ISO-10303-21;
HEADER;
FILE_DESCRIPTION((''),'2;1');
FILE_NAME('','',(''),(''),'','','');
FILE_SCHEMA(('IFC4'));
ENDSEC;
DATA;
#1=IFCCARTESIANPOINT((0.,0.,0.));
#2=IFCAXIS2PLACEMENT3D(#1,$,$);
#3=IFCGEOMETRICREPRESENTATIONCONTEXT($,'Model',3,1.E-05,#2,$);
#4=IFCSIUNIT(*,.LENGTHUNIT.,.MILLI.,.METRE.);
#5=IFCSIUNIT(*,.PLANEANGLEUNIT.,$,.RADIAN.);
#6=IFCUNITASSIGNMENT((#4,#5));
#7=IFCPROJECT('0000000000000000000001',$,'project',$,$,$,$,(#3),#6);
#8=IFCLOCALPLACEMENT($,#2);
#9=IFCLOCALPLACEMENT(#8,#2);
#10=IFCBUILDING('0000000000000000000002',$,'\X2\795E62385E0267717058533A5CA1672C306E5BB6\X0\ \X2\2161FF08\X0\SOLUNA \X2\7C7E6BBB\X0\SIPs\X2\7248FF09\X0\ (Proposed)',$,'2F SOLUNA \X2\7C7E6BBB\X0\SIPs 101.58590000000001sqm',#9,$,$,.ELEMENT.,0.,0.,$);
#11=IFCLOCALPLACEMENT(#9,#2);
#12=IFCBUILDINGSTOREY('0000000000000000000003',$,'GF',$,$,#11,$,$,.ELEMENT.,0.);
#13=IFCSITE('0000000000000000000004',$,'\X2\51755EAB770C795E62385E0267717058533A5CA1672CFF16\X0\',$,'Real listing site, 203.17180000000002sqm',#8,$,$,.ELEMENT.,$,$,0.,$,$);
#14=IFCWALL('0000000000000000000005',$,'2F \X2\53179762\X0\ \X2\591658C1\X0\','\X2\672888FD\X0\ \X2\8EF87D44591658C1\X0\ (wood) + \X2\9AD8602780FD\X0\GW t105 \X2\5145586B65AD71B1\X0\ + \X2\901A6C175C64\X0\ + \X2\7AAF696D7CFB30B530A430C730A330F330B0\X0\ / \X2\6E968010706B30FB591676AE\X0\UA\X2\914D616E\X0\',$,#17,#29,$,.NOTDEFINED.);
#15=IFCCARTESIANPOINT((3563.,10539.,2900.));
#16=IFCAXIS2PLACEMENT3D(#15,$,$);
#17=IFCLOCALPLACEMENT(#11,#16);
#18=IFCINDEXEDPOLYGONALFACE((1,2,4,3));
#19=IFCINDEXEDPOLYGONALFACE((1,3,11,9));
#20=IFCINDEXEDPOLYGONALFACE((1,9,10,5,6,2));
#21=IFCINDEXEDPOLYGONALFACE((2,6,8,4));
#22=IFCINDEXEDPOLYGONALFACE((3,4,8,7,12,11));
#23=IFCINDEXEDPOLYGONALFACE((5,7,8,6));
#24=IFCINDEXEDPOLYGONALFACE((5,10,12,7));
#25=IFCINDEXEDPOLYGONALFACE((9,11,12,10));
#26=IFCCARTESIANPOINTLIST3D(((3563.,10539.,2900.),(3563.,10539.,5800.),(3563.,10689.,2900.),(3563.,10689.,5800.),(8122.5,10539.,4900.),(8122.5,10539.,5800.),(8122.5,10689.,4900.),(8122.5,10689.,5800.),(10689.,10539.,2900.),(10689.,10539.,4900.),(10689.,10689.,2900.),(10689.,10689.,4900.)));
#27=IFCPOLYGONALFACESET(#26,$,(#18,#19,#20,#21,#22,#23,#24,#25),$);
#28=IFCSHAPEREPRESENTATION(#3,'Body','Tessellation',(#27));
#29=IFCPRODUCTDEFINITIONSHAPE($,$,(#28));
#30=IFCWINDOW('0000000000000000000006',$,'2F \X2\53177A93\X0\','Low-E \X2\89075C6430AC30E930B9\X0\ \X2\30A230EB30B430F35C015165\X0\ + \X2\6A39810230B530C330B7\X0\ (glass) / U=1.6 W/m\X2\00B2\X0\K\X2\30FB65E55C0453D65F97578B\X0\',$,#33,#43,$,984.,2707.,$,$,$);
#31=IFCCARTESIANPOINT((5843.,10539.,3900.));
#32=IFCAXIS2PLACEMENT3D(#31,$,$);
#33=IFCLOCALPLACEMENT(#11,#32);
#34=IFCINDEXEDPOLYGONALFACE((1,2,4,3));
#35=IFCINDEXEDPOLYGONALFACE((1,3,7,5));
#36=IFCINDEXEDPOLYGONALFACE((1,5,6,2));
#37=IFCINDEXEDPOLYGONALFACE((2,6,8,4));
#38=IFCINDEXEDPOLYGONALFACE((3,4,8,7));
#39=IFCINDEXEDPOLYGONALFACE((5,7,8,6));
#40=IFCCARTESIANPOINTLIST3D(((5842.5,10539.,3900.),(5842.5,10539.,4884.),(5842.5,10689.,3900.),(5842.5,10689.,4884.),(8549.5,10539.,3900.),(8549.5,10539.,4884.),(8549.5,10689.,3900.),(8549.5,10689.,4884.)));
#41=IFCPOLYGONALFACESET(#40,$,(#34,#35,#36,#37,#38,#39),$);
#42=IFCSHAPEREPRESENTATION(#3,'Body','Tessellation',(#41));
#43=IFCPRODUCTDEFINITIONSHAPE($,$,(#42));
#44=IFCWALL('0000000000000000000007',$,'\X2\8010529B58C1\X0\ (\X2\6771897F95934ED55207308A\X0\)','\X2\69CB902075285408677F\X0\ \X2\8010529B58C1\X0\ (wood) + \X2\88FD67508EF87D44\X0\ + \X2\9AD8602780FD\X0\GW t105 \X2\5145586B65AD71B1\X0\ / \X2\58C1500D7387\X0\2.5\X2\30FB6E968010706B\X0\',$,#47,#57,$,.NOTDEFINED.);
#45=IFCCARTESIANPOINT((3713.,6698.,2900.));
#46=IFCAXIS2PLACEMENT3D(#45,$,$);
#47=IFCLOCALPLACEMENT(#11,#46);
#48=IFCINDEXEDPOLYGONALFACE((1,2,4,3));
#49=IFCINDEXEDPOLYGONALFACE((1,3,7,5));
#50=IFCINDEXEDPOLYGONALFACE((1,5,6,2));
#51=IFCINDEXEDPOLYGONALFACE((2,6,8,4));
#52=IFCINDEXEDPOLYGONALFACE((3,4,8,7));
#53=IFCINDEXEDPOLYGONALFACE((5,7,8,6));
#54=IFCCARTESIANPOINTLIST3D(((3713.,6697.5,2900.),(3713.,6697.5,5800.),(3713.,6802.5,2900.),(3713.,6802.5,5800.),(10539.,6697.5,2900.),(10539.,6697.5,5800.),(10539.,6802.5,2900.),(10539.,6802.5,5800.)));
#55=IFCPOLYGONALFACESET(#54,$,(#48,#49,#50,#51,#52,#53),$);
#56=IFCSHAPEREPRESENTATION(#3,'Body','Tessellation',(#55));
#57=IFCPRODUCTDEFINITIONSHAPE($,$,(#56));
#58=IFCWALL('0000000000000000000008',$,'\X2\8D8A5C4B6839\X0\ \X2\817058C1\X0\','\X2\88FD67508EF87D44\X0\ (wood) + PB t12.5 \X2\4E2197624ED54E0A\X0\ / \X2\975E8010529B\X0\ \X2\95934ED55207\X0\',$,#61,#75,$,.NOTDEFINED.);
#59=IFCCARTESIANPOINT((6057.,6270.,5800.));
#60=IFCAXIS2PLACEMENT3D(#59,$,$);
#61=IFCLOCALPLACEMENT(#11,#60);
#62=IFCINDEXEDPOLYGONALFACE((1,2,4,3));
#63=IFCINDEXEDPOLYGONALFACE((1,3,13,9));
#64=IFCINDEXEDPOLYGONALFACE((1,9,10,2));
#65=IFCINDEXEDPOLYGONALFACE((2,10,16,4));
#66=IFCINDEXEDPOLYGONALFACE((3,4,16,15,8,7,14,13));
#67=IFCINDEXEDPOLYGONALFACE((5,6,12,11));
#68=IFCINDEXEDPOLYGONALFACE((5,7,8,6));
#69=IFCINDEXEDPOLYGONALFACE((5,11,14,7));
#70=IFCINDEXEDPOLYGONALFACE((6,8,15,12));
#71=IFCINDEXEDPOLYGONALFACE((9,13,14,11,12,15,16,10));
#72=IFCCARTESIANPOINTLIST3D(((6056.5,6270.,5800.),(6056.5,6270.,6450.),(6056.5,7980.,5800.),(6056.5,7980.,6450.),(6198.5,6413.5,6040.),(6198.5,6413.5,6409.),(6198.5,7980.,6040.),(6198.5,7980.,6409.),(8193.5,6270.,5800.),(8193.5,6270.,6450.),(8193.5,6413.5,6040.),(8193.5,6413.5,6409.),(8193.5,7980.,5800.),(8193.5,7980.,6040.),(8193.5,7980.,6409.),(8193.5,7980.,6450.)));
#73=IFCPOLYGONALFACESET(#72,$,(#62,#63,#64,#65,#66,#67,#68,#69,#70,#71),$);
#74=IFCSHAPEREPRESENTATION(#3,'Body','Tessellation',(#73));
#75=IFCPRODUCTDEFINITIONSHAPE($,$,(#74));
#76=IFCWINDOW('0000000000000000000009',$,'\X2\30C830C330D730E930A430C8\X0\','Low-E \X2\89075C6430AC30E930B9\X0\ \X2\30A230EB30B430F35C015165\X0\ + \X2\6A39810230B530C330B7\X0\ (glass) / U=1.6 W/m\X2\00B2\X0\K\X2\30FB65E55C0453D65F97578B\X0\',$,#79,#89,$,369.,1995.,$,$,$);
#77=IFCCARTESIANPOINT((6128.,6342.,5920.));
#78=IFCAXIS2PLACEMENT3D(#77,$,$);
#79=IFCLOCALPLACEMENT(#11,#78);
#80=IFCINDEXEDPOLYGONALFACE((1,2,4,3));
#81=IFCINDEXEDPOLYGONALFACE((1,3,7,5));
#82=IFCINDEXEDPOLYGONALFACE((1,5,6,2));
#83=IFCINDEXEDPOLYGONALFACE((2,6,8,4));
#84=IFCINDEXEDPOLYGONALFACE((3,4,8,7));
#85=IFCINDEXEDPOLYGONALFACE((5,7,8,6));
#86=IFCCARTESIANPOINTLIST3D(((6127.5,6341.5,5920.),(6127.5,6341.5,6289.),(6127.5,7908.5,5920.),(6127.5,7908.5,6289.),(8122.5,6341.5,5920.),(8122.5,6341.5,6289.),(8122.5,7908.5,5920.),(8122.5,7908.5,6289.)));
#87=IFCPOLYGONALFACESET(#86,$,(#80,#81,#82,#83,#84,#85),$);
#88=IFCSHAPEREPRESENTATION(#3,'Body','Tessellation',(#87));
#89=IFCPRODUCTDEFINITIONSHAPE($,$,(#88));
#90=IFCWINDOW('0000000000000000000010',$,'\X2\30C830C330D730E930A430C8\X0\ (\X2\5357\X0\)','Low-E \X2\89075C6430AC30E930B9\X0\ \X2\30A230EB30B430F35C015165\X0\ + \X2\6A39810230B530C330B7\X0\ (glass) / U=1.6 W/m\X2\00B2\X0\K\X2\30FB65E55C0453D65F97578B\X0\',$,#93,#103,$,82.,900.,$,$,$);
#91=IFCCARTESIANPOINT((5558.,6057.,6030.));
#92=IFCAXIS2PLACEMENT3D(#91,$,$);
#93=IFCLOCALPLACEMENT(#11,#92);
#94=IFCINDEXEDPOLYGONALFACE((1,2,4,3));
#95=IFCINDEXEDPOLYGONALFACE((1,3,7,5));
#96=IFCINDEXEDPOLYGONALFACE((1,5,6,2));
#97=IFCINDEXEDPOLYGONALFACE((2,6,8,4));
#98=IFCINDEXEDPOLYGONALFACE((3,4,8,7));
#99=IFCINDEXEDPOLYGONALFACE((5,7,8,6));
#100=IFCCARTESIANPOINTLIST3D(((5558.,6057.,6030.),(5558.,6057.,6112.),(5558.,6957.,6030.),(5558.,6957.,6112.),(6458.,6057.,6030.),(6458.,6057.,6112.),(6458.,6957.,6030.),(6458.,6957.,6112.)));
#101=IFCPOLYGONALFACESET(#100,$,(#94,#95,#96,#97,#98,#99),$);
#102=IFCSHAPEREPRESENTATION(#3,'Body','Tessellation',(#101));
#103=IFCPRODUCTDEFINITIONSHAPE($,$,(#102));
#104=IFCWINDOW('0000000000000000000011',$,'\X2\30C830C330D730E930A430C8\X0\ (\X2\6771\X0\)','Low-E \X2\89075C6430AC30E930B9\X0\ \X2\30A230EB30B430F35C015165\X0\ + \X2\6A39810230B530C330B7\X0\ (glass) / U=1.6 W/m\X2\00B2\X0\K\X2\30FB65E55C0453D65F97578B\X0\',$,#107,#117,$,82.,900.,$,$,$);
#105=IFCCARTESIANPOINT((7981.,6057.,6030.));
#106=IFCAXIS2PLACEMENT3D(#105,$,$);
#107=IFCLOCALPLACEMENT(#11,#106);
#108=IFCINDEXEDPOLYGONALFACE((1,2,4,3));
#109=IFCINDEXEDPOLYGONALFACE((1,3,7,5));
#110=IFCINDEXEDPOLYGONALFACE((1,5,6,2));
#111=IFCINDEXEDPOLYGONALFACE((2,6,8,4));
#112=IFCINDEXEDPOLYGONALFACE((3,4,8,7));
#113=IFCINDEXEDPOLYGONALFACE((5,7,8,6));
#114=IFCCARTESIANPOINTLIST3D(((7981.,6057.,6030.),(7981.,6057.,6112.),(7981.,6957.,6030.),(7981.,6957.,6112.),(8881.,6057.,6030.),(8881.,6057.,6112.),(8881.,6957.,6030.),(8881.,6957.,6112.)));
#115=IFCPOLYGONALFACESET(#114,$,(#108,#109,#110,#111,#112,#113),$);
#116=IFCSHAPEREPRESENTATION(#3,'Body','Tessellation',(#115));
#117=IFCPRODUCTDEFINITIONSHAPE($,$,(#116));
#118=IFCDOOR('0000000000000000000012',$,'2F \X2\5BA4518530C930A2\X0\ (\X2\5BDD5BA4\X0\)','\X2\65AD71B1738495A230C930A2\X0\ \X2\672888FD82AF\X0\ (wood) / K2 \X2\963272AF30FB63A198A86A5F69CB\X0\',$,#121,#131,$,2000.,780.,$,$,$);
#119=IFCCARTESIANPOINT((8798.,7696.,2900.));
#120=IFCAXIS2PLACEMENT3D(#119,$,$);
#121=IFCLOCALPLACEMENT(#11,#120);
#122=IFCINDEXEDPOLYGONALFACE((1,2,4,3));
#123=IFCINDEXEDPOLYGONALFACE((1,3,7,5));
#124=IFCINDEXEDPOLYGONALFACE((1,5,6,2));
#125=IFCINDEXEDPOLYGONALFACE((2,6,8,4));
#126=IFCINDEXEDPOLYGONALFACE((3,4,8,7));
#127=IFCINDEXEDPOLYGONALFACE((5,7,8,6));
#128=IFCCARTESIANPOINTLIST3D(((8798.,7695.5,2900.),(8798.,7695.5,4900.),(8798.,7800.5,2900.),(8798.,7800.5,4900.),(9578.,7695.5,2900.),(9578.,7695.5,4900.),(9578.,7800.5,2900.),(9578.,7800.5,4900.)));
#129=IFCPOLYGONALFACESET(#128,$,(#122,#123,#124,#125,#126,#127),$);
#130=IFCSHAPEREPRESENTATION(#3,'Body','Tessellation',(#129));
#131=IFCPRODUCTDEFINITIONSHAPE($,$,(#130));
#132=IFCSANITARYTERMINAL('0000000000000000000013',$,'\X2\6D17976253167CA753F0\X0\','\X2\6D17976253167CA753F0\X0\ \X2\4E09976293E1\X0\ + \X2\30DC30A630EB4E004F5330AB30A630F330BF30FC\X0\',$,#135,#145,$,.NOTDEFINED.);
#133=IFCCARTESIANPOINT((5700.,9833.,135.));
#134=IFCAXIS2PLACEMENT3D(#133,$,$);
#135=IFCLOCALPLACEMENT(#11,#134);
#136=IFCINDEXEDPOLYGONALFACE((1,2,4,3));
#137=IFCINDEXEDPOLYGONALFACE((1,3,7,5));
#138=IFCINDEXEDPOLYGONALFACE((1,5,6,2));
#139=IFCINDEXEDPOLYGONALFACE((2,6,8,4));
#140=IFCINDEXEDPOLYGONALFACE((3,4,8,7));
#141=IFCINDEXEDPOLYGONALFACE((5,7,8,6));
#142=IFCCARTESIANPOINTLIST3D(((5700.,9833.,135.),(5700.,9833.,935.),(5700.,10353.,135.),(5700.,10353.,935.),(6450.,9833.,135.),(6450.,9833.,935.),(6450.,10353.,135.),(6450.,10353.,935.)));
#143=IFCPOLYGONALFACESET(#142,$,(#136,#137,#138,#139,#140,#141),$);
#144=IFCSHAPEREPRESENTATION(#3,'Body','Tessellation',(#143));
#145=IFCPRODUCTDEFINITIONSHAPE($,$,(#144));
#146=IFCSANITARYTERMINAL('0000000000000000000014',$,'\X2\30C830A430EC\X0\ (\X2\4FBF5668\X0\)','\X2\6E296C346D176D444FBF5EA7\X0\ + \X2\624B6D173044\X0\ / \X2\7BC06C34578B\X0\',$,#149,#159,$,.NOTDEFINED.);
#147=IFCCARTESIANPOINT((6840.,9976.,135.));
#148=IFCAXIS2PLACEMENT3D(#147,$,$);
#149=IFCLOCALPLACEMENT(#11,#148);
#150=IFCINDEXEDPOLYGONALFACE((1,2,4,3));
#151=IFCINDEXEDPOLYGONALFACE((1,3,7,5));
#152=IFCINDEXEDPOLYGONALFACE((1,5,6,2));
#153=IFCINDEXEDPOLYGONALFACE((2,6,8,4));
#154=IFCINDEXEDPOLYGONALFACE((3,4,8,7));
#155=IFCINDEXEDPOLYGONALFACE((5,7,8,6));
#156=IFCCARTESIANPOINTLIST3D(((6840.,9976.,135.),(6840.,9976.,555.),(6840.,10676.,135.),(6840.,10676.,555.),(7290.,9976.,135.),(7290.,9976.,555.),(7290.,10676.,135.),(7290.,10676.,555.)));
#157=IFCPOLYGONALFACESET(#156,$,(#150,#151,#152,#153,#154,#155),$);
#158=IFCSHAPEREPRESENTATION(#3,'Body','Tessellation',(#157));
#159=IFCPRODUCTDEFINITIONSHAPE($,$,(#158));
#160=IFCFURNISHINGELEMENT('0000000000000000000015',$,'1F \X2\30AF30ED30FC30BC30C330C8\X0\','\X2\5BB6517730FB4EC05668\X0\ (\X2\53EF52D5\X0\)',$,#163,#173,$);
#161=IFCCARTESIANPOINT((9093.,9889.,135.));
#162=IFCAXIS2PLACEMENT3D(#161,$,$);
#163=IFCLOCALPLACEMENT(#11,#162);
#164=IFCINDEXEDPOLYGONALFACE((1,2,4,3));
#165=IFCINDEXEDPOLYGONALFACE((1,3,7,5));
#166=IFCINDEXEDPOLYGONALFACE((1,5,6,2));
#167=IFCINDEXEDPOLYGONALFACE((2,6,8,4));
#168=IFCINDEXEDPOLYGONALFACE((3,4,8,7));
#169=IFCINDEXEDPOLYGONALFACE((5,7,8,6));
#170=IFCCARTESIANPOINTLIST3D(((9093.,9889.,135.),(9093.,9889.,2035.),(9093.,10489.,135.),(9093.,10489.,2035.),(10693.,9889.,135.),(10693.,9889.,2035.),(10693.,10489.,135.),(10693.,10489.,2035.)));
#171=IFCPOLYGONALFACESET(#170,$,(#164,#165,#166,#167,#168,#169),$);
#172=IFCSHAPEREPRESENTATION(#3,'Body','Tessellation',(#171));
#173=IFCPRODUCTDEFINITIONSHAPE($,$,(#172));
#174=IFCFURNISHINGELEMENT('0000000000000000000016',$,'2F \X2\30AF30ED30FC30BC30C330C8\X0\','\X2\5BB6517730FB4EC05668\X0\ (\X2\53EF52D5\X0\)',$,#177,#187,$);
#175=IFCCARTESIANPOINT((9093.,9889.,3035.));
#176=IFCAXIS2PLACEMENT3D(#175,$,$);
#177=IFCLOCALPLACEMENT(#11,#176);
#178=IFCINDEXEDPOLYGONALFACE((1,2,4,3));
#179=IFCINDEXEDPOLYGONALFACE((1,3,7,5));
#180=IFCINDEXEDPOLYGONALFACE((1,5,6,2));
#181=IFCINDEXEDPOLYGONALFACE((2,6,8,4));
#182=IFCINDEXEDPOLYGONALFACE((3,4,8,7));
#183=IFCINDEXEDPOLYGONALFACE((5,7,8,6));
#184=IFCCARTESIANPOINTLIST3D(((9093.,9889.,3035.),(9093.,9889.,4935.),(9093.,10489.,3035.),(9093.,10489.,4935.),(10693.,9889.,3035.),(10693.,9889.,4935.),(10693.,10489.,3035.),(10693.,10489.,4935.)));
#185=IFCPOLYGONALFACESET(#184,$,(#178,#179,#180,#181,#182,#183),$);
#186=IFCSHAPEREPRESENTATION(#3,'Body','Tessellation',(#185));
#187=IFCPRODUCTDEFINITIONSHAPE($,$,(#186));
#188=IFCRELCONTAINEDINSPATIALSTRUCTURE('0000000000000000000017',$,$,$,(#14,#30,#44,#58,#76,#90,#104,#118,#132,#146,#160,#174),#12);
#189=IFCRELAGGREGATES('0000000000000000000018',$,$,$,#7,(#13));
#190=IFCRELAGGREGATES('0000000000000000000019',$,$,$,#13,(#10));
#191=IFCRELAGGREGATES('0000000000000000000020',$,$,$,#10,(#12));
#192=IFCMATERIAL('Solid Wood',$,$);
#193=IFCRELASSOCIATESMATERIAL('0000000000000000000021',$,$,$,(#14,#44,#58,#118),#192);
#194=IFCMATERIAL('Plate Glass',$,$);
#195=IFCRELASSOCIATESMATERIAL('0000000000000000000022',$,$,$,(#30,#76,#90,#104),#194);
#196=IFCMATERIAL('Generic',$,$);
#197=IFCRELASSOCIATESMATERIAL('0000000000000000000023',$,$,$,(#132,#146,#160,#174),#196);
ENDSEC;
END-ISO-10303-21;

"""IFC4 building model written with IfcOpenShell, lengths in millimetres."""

from ifc_helpers import new_model, si_unit, frame, frame_2d, origin, place, context, project, spatial, rectangle, extrude, material, element, fill, save


model = new_model("IFC4")

# Units and contexts
model_context = context("Model", 3, precision=1e-05, world=origin())
ifc_project = project(units=[si_unit("LENGTHUNIT", "METRE", prefix="MILLI"), si_unit("PLANEANGLEUNIT", "RADIAN")], contexts=[model_context])

# Site, building, storey
site_placement = place(None, origin())
site = spatial("IfcSite", under=ifc_project, at=site_placement, Name="兵庫県神戸市東灘区岡本６", ObjectType="Real listing site, 203.17180000000002sqm", CompositionType="ELEMENT", RefElevation=0.0)
building_placement = place(site_placement, origin())
building = spatial("IfcBuilding", under=site, at=building_placement, Name="神戸市東灘区岡本の家 Ⅱ（SOLUNA 籾殻SIPs版） (Proposed)", ObjectType="2F SOLUNA 籾殻SIPs 101.58590000000001sqm", CompositionType="ELEMENT", ElevationOfRefHeight=0.0, ElevationOfTerrain=0.0)
storey_placement = place(building_placement, origin())
storey = spatial("IfcBuildingStorey", under=building, at=storey_placement, Name="GF", CompositionType="ELEMENT", Elevation=0.0)

# Wall, opening, window
ifc_material_1 = material(Name="Solid Wood")
wall_1_placement = place(storey_placement, frame((3563.0, 10539.0, 2900.0)))
wall_1 = element("IfcWall", 1, at=wall_1_placement, inside=storey, material=ifc_material_1, Name="2F 北面 外壁", Description="木製 軸組外壁 (wood) + 高性能GW t105 充填断熱 + 通気層 + 窯業系サイディング / 準耐火・外皮UA配慮", PredefinedType="NOTDEFINED", context=model_context, shape_type="SweptSolid", body=[
    extrude(rectangle(XDim=7126.0, YDim=150.0, at=frame_2d((3563.0, 75.0))), frame((3563.0, 10539.0, 2900.0)), (0.0, 0.0, 1.0), 2900.0),
])
opening_1_placement = place(storey_placement, frame((5843.0, 10539.0, 3900.0)))
opening_1 = element("IfcOpeningElement", 2, at=opening_1_placement, cuts=wall_1, PredefinedType="NOTDEFINED", context=model_context, shape_type="SweptSolid", body=[
    extrude(rectangle(XDim=2707.0, YDim=150.0, at=frame_2d((1353.0, 75.0))), frame((5843.0, 10539.0, 3900.0)), (0.0, 0.0, 1.0), 984.0),
])
ifc_material_2 = material(Name="Plate Glass")
window_1_placement = place(storey_placement, frame((5843.0, 10539.0, 3900.0)))
window_1 = element("IfcWindow", 3, at=window_1_placement, inside=storey, material=ifc_material_2, Name="2F 北窓", Description="Low-E 複層ガラス アルゴン封入 + 樹脂サッシ (glass) / U=1.6 W/m²K・日射取得型", OverallHeight=984.0, OverallWidth=2707.0, context=model_context, shape_type="SweptSolid", body=[
    extrude(rectangle(XDim=2707.0, YDim=150.0, at=frame_2d((1353.0, 75.0))), frame((5843.0, 10539.0, 3900.0)), (0.0, 0.0, 1.0), 984.0),
])
fill(opening_1, window_1)

# Wall
wall_2_placement = place(storey_placement, frame((3713.0, 6698.0, 2900.0)))
element("IfcWall", 4, at=wall_2_placement, inside=storey, material=ifc_material_1, Name="耐力壁 (東西間仕切り)", Description="構造用合板 耐力壁 (wood) + 製材軸組 + 高性能GW t105 充填断熱 / 壁倍率2.5・準耐火", PredefinedType="NOTDEFINED", context=model_context, shape_type="SweptSolid", body=[
    extrude(rectangle(XDim=6826.0, YDim=105.0, at=frame_2d((3413.0, 52.0))), frame((3713.0, 6698.0, 2900.0)), (0.0, 0.0, 1.0), 2900.0),
])

# Wall, openings, windows
wall_3_placement = place(storey_placement, frame((6057.0, 6270.0, 5800.0)))
wall_3 = element("IfcWall", 5, at=wall_3_placement, inside=storey, material=ifc_material_1, Name="越屋根 腰壁", Description="製材軸組 (wood) + PB t12.5 両面仕上 / 非耐力 間仕切", PredefinedType="NOTDEFINED", context=model_context, shape_type="SweptSolid", body=[
    extrude(rectangle(XDim=2137.0, YDim=1710.0, at=frame_2d((1068.0, 855.0))), frame((6057.0, 6270.0, 5800.0)), (0.0, 0.0, 1.0), 650.0),
])
opening_2_placement = place(storey_placement, frame((6128.0, 6342.0, 5920.0)))
opening_2 = element("IfcOpeningElement", 6, at=opening_2_placement, cuts=wall_3, PredefinedType="NOTDEFINED", context=model_context, shape_type="SweptSolid", body=[
    extrude(rectangle(XDim=1995.0, YDim=1567.0, at=frame_2d((997.0, 783.0))), frame((6128.0, 6342.0, 5920.0)), (0.0, 0.0, 1.0), 369.0),
])
opening_3_placement = place(storey_placement, frame((5558.0, 6057.0, 6030.0)))
opening_3 = element("IfcOpeningElement", 7, at=opening_3_placement, cuts=wall_3, PredefinedType="NOTDEFINED", context=model_context, shape_type="SweptSolid", body=[
    extrude(rectangle(XDim=900.0, YDim=900.0, at=frame_2d((450.0, 450.0))), frame((5558.0, 6057.0, 6030.0)), (0.0, 0.0, 1.0), 82.0),
])
opening_4_placement = place(storey_placement, frame((7981.0, 6057.0, 6030.0)))
opening_4 = element("IfcOpeningElement", 8, at=opening_4_placement, cuts=wall_3, PredefinedType="NOTDEFINED", context=model_context, shape_type="SweptSolid", body=[
    extrude(rectangle(XDim=900.0, YDim=900.0, at=frame_2d((450.0, 450.0))), frame((7981.0, 6057.0, 6030.0)), (0.0, 0.0, 1.0), 82.0),
])
window_2_placement = place(storey_placement, frame((6128.0, 6342.0, 5920.0)))
window_2 = element("IfcWindow", 9, at=window_2_placement, inside=storey, material=ifc_material_2, Name="トップライト", Description="Low-E 複層ガラス アルゴン封入 + 樹脂サッシ (glass) / U=1.6 W/m²K・日射取得型", OverallHeight=369.0, OverallWidth=1995.0, context=model_context, shape_type="SweptSolid", body=[
    extrude(rectangle(XDim=1995.0, YDim=1567.0, at=frame_2d((997.0, 783.0))), frame((6128.0, 6342.0, 5920.0)), (0.0, 0.0, 1.0), 369.0),
])
fill(opening_2, window_2)
window_3_placement = place(storey_placement, frame((5558.0, 6057.0, 6030.0)))
window_3 = element("IfcWindow", 10, at=window_3_placement, inside=storey, material=ifc_material_2, Name="トップライト (南)", Description="Low-E 複層ガラス アルゴン封入 + 樹脂サッシ (glass) / U=1.6 W/m²K・日射取得型", OverallHeight=82.0, OverallWidth=900.0, context=model_context, shape_type="SweptSolid", body=[
    extrude(rectangle(XDim=900.0, YDim=900.0, at=frame_2d((450.0, 450.0))), frame((5558.0, 6057.0, 6030.0)), (0.0, 0.0, 1.0), 82.0),
])
fill(opening_3, window_3)
window_4_placement = place(storey_placement, frame((7981.0, 6057.0, 6030.0)))
window_4 = element("IfcWindow", 11, at=window_4_placement, inside=storey, material=ifc_material_2, Name="トップライト (東)", Description="Low-E 複層ガラス アルゴン封入 + 樹脂サッシ (glass) / U=1.6 W/m²K・日射取得型", OverallHeight=82.0, OverallWidth=900.0, context=model_context, shape_type="SweptSolid", body=[
    extrude(rectangle(XDim=900.0, YDim=900.0, at=frame_2d((450.0, 450.0))), frame((7981.0, 6057.0, 6030.0)), (0.0, 0.0, 1.0), 82.0),
])
fill(opening_4, window_4)

# Door
door_placement = place(storey_placement, frame((8798.0, 7696.0, 2900.0)))
element("IfcDoor", 12, at=door_placement, inside=storey, material=ifc_material_1, Name="2F 室内ドア (寝室)", Description="断熱玄関ドア 木製芯 (wood) / K2 防犯・採風機構", OverallHeight=2000.0, OverallWidth=780.0, context=model_context, shape_type="SweptSolid", body=[
    extrude(rectangle(XDim=780.0, YDim=105.0, at=frame_2d((390.0, 52.0))), frame((8798.0, 7696.0, 2900.0)), (0.0, 0.0, 1.0), 2000.0),
])

# Sanitary terminals
ifc_material_3 = material(Name="Generic")
sanitary_terminal_1_placement = place(storey_placement, frame((5700.0, 9833.0, 135.0)))
element("IfcSanitaryTerminal", 13, at=sanitary_terminal_1_placement, inside=storey, material=ifc_material_3, Name="洗面化粧台", Description="洗面化粧台 三面鏡 + ボウル一体カウンター", PredefinedType="NOTDEFINED", context=model_context, shape_type="SweptSolid", body=[
    extrude(rectangle(XDim=750.0, YDim=520.0, at=frame_2d((375.0, 260.0))), frame((5700.0, 9833.0, 135.0)), (0.0, 0.0, 1.0), 800.0),
])
sanitary_terminal_2_placement = place(storey_placement, frame((6840.0, 9976.0, 135.0)))
element("IfcSanitaryTerminal", 14, at=sanitary_terminal_2_placement, inside=storey, material=ifc_material_3, Name="トイレ (便器)", Description="温水洗浄便座 + 手洗い / 節水型", PredefinedType="NOTDEFINED", context=model_context, shape_type="SweptSolid", body=[
    extrude(rectangle(XDim=450.0, YDim=700.0, at=frame_2d((225.0, 350.0))), frame((6840.0, 9976.0, 135.0)), (0.0, 0.0, 1.0), 420.0),
])

# Furnishing elements
furnishing_1_placement = place(storey_placement, frame((9093.0, 9889.0, 135.0)))
element("IfcFurnishingElement", 15, at=furnishing_1_placement, inside=storey, material=ifc_material_3, Name="1F クローゼット", Description="家具・什器 (可動)", context=model_context, shape_type="SweptSolid", body=[
    extrude(rectangle(XDim=1600.0, YDim=600.0, at=frame_2d((800.0, 300.0))), frame((9093.0, 9889.0, 135.0)), (0.0, 0.0, 1.0), 1900.0),
])
furnishing_2_placement = place(storey_placement, frame((9093.0, 9889.0, 3035.0)))
element("IfcFurnishingElement", 16, at=furnishing_2_placement, inside=storey, material=ifc_material_3, Name="2F クローゼット", Description="家具・什器 (可動)", context=model_context, shape_type="SweptSolid", body=[
    extrude(rectangle(XDim=1600.0, YDim=600.0, at=frame_2d((800.0, 300.0))), frame((9093.0, 9889.0, 3035.0)), (0.0, 0.0, 1.0), 1900.0),
])

save(model, "model.ifc")
